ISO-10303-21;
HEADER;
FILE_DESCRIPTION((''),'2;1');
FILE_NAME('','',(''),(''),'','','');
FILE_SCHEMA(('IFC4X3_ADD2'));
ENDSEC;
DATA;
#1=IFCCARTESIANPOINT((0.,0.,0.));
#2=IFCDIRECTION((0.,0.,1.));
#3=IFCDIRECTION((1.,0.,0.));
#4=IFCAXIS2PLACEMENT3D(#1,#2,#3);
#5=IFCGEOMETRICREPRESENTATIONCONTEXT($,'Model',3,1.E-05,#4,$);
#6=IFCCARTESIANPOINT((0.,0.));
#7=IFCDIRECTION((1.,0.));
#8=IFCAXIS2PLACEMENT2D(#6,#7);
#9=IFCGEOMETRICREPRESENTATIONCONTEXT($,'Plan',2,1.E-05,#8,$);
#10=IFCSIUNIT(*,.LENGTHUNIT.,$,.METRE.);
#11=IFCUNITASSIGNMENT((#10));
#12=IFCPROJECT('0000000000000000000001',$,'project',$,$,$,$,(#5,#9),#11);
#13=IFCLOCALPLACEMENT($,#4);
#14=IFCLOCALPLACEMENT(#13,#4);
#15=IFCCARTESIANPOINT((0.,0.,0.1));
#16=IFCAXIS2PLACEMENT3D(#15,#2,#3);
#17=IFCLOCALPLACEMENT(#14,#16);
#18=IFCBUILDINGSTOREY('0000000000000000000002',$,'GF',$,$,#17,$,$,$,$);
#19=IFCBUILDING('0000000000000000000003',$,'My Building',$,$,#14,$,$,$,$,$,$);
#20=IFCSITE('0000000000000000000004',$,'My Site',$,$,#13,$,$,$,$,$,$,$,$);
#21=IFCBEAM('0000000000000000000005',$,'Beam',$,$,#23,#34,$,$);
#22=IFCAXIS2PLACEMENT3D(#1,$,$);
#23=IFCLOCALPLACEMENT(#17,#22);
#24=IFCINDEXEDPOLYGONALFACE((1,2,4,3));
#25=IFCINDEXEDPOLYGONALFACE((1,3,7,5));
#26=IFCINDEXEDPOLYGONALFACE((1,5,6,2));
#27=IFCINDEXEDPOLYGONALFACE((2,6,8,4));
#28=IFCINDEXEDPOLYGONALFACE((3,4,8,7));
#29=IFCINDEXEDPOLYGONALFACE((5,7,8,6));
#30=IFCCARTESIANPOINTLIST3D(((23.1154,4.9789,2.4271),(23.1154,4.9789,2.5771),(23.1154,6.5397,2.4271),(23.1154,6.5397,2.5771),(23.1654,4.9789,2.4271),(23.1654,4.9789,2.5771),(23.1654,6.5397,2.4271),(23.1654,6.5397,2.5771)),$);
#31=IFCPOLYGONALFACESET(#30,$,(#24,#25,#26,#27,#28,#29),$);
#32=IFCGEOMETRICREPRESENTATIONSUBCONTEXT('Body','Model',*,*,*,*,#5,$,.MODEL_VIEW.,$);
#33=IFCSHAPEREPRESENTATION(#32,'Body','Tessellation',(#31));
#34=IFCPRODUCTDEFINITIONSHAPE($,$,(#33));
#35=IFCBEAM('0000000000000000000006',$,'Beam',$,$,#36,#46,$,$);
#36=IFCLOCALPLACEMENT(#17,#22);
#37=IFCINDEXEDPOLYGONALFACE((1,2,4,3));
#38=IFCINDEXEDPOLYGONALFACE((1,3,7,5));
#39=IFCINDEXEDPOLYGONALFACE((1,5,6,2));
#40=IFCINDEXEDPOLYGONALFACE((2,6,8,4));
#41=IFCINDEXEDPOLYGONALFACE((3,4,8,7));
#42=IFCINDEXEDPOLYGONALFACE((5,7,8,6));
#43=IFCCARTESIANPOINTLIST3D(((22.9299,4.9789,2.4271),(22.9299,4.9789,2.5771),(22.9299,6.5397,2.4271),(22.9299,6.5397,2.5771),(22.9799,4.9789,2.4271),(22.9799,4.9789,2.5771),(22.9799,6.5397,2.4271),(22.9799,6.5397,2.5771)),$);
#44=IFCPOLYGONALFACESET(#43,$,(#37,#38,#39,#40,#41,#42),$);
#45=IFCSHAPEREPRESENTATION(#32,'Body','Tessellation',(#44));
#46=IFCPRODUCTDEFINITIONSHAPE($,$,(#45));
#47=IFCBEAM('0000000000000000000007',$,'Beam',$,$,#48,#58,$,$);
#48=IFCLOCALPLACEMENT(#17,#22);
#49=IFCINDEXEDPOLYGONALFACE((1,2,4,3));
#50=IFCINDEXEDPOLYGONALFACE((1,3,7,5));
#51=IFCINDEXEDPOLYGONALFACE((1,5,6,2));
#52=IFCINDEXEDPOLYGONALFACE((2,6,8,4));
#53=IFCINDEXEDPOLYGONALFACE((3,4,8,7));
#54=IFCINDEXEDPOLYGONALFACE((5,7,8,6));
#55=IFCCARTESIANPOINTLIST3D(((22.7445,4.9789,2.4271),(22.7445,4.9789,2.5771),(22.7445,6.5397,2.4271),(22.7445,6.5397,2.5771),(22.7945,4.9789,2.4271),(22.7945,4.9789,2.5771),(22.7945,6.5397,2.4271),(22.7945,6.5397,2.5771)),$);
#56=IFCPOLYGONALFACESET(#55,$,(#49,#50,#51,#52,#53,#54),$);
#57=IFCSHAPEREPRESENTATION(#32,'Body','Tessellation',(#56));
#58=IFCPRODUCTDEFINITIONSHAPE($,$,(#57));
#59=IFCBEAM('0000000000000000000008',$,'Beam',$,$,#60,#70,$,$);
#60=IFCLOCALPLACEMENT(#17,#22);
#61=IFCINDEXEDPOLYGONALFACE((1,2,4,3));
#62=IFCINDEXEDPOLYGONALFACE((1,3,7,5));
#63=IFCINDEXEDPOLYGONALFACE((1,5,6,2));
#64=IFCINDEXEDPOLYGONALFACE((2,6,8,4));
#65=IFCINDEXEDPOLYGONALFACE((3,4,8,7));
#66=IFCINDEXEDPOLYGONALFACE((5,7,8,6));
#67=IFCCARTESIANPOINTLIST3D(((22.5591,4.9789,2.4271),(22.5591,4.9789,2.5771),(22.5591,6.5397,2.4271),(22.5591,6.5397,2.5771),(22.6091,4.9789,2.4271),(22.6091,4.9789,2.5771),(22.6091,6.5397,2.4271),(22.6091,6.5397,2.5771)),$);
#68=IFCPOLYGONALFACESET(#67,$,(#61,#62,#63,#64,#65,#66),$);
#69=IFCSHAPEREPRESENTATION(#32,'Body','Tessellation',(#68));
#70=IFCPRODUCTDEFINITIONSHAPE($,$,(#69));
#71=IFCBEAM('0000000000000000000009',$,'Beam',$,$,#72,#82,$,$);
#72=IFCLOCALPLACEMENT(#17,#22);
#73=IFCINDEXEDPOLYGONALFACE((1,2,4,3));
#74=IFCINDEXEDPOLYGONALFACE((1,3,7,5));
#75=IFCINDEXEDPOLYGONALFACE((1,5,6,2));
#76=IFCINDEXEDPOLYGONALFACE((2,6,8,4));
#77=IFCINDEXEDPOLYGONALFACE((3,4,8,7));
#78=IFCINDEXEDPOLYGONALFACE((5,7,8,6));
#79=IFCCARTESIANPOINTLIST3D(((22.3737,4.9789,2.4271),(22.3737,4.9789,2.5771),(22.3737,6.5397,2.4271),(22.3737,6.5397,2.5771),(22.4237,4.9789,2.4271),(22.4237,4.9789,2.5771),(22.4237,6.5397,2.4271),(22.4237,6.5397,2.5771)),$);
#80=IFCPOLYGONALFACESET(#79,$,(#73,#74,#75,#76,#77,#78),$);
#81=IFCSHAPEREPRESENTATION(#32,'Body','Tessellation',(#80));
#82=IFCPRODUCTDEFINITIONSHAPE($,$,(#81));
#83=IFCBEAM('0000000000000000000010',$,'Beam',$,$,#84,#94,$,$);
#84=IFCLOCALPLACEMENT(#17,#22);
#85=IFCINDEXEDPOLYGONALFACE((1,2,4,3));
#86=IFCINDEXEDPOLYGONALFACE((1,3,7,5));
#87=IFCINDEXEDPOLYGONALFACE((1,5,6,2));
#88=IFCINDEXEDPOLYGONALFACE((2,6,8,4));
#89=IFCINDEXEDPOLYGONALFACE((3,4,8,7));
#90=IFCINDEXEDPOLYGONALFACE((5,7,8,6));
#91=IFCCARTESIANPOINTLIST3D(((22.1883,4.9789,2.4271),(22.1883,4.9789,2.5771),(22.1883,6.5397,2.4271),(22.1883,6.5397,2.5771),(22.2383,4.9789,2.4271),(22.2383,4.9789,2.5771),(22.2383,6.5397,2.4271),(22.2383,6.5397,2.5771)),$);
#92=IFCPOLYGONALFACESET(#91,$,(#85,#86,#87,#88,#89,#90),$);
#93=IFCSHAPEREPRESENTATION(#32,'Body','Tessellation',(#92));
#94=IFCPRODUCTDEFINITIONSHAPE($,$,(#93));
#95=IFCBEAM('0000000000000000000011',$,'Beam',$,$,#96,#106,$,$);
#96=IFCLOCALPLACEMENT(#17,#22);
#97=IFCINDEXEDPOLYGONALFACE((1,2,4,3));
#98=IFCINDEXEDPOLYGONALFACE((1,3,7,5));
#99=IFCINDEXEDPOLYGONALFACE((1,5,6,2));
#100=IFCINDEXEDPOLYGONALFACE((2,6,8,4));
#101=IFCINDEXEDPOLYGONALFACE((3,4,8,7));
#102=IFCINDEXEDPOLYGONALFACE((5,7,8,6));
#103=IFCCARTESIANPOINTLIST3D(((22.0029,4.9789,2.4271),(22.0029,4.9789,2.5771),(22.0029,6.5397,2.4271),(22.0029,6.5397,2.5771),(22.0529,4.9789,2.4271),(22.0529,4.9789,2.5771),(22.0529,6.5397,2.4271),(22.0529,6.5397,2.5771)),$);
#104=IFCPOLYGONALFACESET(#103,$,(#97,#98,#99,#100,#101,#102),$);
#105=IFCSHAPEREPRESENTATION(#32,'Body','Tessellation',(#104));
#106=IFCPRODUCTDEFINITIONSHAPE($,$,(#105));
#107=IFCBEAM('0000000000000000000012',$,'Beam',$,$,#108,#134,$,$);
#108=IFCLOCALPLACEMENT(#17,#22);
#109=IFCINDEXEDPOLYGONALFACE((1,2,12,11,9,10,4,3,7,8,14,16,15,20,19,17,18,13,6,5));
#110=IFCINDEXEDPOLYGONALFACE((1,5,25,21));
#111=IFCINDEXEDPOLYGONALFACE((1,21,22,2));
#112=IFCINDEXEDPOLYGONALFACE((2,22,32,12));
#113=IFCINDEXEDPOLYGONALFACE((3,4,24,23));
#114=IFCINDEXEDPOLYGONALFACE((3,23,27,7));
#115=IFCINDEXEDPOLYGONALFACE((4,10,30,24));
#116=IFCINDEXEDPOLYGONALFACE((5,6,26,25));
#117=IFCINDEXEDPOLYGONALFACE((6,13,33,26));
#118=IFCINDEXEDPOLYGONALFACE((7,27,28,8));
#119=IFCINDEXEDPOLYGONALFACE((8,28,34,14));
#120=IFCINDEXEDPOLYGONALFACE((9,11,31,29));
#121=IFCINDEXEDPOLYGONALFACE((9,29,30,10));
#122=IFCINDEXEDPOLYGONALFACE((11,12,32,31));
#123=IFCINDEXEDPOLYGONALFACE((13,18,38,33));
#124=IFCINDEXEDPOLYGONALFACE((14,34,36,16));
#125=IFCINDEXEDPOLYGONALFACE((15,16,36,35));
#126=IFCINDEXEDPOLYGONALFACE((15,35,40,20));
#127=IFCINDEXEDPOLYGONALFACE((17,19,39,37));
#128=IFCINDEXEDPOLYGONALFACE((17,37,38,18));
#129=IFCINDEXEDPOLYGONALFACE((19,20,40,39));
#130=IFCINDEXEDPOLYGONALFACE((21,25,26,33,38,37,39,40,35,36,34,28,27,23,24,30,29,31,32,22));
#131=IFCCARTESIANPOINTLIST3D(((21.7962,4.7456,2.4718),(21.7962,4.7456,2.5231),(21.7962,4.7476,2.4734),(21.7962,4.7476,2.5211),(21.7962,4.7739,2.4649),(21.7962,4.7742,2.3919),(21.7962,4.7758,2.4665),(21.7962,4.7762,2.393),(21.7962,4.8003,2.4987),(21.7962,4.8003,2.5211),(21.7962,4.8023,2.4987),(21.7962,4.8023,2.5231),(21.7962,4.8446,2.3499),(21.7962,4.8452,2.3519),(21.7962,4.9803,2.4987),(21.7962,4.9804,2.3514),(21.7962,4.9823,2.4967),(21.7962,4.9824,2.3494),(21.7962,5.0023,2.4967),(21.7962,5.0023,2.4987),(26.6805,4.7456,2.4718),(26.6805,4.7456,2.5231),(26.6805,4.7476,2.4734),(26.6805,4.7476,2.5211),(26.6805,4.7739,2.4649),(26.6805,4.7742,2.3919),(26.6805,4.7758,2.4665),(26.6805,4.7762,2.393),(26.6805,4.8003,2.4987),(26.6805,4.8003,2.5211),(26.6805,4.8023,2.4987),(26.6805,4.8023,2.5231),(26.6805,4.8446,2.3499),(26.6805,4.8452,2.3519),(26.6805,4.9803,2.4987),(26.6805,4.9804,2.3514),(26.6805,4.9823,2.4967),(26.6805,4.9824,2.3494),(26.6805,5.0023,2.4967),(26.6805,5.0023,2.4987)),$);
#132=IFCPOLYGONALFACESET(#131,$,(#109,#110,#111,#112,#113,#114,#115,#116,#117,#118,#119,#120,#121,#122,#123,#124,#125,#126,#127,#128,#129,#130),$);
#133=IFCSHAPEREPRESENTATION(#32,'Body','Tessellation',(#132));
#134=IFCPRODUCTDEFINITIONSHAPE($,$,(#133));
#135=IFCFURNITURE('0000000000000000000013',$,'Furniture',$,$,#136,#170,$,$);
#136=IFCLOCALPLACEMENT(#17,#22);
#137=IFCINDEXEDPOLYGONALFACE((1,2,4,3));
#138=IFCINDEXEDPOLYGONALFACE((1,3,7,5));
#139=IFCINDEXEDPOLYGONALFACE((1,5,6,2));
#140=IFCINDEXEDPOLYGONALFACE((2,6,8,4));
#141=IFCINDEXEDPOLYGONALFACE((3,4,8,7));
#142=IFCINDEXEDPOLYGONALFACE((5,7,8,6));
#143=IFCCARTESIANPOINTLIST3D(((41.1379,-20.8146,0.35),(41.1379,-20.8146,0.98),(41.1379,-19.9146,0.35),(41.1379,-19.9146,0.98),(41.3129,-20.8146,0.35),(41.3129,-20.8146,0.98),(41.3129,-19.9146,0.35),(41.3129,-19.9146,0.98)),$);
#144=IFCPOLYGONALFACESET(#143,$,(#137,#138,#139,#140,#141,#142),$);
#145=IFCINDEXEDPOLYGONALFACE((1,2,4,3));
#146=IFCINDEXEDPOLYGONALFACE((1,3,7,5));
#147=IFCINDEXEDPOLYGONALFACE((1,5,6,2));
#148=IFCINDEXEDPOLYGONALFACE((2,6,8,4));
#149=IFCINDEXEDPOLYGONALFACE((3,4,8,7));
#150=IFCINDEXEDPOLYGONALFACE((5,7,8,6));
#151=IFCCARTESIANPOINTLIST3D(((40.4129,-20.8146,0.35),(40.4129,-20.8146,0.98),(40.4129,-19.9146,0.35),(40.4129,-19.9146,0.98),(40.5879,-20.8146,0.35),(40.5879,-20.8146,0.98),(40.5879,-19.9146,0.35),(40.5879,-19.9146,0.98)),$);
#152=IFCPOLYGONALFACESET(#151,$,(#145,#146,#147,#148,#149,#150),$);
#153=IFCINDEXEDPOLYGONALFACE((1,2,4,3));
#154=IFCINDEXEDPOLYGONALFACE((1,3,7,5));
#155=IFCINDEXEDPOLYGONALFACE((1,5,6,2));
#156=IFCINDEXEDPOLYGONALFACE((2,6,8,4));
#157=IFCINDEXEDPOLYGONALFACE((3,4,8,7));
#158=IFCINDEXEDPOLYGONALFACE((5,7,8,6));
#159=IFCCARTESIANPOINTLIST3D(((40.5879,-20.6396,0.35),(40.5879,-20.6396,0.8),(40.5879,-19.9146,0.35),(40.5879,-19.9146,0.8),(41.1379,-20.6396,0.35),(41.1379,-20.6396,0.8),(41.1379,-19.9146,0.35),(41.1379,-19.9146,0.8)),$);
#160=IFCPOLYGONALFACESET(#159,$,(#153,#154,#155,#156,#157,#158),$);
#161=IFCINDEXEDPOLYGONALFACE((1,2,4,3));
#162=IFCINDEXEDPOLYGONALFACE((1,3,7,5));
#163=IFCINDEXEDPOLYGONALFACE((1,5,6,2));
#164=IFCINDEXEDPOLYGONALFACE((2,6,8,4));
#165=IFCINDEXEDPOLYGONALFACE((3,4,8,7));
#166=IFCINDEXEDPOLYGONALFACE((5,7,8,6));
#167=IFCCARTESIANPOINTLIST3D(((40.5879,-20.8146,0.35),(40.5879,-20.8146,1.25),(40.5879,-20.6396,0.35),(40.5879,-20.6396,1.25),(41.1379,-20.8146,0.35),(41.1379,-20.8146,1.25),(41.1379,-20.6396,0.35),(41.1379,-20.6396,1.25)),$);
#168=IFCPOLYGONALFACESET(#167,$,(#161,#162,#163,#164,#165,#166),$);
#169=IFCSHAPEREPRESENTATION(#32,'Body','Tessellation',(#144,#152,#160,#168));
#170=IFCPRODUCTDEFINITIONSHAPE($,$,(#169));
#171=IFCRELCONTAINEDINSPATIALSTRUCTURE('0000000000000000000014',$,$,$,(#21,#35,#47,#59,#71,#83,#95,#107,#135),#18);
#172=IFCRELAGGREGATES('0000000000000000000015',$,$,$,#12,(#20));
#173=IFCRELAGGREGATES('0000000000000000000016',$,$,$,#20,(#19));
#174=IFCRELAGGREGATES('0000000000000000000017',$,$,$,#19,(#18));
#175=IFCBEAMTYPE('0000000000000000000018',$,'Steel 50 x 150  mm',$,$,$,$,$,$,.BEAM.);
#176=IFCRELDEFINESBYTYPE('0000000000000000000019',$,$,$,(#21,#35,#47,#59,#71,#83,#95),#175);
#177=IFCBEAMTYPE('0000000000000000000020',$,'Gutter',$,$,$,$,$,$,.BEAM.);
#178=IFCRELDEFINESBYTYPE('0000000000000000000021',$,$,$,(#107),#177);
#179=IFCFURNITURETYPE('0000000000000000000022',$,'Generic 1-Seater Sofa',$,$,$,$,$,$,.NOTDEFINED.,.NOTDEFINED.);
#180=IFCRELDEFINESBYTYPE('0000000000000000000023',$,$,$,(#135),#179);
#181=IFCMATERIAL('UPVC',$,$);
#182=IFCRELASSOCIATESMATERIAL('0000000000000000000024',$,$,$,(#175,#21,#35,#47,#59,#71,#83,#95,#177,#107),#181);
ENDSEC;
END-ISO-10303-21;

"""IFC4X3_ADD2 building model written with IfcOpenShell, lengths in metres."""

from ifc_helpers import new_model, entity, si_unit, frame, origin_with_axes, origin_2d_with_axis, place, context, subcontext, project, spatial, line, indexed_curve, rectangle, outline, extrude, shape, source, transform, mapped, material, material_profile, profile_set, profile_usage, type_object, type_shapes, element, save


model = new_model("IFC4X3_ADD2")

# Units and contexts
model_context = context("Model", 3, precision=1e-05, world=origin_with_axes())
plan_context = context("Plan", 2, precision=1e-05, world=origin_2d_with_axis())
body_context_1 = subcontext(model_context, "Body", "Model", "MODEL_VIEW")
body_context_2 = subcontext(plan_context, "Body", "Plan", "PLAN_VIEW")
ifc_project = project(units=[si_unit("LENGTHUNIT", "METRE")], contexts=[model_context, plan_context])

# Site, building, storey
site_placement = place(None, origin_with_axes())
site = spatial("IfcSite", under=ifc_project, at=site_placement, Name="My Site")
building_placement = place(site_placement, origin_with_axes())
building = spatial("IfcBuilding", under=site, at=building_placement, Name="My Building")
storey_placement = place(building_placement, frame((0.0, 0.0, 0.1), z_axis=(0.0, 0.0, 1.0), x_axis=(1.0, 0.0, 0.0)))
storey = spatial("IfcBuildingStorey", under=building, at=storey_placement, Name="GF")

# Beams
ifc_material_1 = material(Name="UPVC")
ifc_material_profile_1 = material_profile(ifc_material_1, rectangle(XDim=0.05, YDim=0.15))
ifc_profile_set_1 = profile_set([ifc_material_profile_1])
beam_type_1 = type_object("IfcBeamType", Name="Steel 50 x 150  mm", PredefinedType="BEAM", material=ifc_profile_set_1)
ifc_profile_usage_1 = profile_usage(ifc_profile_set_1)
beam_1_placement = place(storey_placement, frame((23.1404, 6.5397, 2.5021), z_axis=(0.0, -1.0, 0.0), x_axis=(1.0, 0.0, 0.0)))
element("IfcBeam", 1, at=beam_1_placement, inside=storey, type_object=beam_type_1, material=ifc_profile_usage_1, Name="Beam", context=body_context_1, shape_type="SweptSolid", body=[
    extrude(rectangle(XDim=0.05, YDim=0.15), origin_with_axes(), (0.0, 0.0, 1.0), 1.5608),
])
ifc_profile_usage_2 = profile_usage(ifc_profile_set_1)
beam_2_placement = place(storey_placement, frame((22.9549, 6.5397, 2.5021), z_axis=(0.0, -1.0, 0.0), x_axis=(1.0, 0.0, 0.0)))
element("IfcBeam", 2, at=beam_2_placement, inside=storey, type_object=beam_type_1, material=ifc_profile_usage_2, Name="Beam", context=body_context_1, shape_type="SweptSolid", body=[
    extrude(rectangle(XDim=0.05, YDim=0.15), origin_with_axes(), (0.0, 0.0, 1.0), 1.5608),
])
ifc_profile_usage_3 = profile_usage(ifc_profile_set_1)
beam_3_placement = place(storey_placement, frame((22.7695, 6.5397, 2.5021), z_axis=(0.0, -1.0, 0.0), x_axis=(1.0, 0.0, 0.0)))
element("IfcBeam", 3, at=beam_3_placement, inside=storey, type_object=beam_type_1, material=ifc_profile_usage_3, Name="Beam", context=body_context_1, shape_type="SweptSolid", body=[
    extrude(rectangle(XDim=0.05, YDim=0.15), origin_with_axes(), (0.0, 0.0, 1.0), 1.5608),
])
ifc_profile_usage_4 = profile_usage(ifc_profile_set_1)
beam_4_placement = place(storey_placement, frame((22.5841, 6.5397, 2.5021), z_axis=(0.0, -1.0, 0.0), x_axis=(1.0, 0.0, 0.0)))
element("IfcBeam", 4, at=beam_4_placement, inside=storey, type_object=beam_type_1, material=ifc_profile_usage_4, Name="Beam", context=body_context_1, shape_type="SweptSolid", body=[
    extrude(rectangle(XDim=0.05, YDim=0.15), origin_with_axes(), (0.0, 0.0, 1.0), 1.5608),
])
ifc_profile_usage_5 = profile_usage(ifc_profile_set_1)
beam_5_placement = place(storey_placement, frame((22.3987, 6.5397, 2.5021), z_axis=(0.0, -1.0, 0.0), x_axis=(1.0, 0.0, 0.0)))
element("IfcBeam", 5, at=beam_5_placement, inside=storey, type_object=beam_type_1, material=ifc_profile_usage_5, Name="Beam", context=body_context_1, shape_type="SweptSolid", body=[
    extrude(rectangle(XDim=0.05, YDim=0.15), origin_with_axes(), (0.0, 0.0, 1.0), 1.5608),
])
ifc_profile_usage_6 = profile_usage(ifc_profile_set_1)
beam_6_placement = place(storey_placement, frame((22.2133, 6.5397, 2.5021), z_axis=(0.0, -1.0, 0.0), x_axis=(1.0, 0.0, 0.0)))
element("IfcBeam", 6, at=beam_6_placement, inside=storey, type_object=beam_type_1, material=ifc_profile_usage_6, Name="Beam", context=body_context_1, shape_type="SweptSolid", body=[
    extrude(rectangle(XDim=0.05, YDim=0.15), origin_with_axes(), (0.0, 0.0, 1.0), 1.5608),
])
ifc_profile_usage_7 = profile_usage(ifc_profile_set_1)
beam_7_placement = place(storey_placement, frame((22.0279, 6.5397, 2.5021), z_axis=(0.0, -1.0, 0.0), x_axis=(1.0, 0.0, 0.0)))
element("IfcBeam", 7, at=beam_7_placement, inside=storey, type_object=beam_type_1, material=ifc_profile_usage_7, Name="Beam", context=body_context_1, shape_type="SweptSolid", body=[
    extrude(rectangle(XDim=0.05, YDim=0.15), origin_with_axes(), (0.0, 0.0, 1.0), 1.5608),
])
ifc_material_profile_2 = material_profile(ifc_material_1, outline(indexed_curve([(0.0548, 0.1717), (0.002, 0.1717), (0.002, 0.124), (0.0303, 0.1171), (0.0307, 0.0436), (0.0996, 0.0025), (0.2349, 0.002), (0.2347, 0.1494), (0.2567, 0.1494), (0.2567, 0.1474), (0.2367, 0.1474), (0.2369, 0.0), (0.0991, 0.0005), (0.0287, 0.0425), (0.0283, 0.1155), (0.0, 0.1224), (0.0, 0.1737), (0.0568, 0.1737), (0.0568, 0.1494), (0.0548, 0.1494), (0.0548, 0.1717)])))
ifc_profile_set_2 = profile_set([ifc_material_profile_2])
ifc_profile_usage_8 = profile_usage(ifc_profile_set_2)
beam_type_2 = type_object("IfcBeamType", Name="Gutter", PredefinedType="BEAM", material=ifc_profile_set_2)
beam_8_placement = place(storey_placement, frame((21.7962, 4.7456, 2.3494), z_axis=(1.0, 0.0, 0.0), x_axis=(0.0, 1.0, 0.0)))
element("IfcBeam", 8, at=beam_8_placement, inside=storey, type_object=beam_type_2, material=ifc_profile_usage_8, Name="Beam", context=body_context_1, shape_type="SweptSolid", body=[
    extrude(outline(indexed_curve([(0.0548, 0.1717), (0.002, 0.1717), (0.002, 0.124), (0.0303, 0.1171), (0.0307, 0.0436), (0.0996, 0.0025), (0.2349, 0.002), (0.2347, 0.1494), (0.2567, 0.1494), (0.2567, 0.1474), (0.2367, 0.1474), (0.2369, 0.0), (0.0991, 0.0005), (0.0287, 0.0425), (0.0283, 0.1155), (0.0, 0.1224), (0.0, 0.1737), (0.0568, 0.1737), (0.0568, 0.1494), (0.0548, 0.1494), (0.0548, 0.1717)])), origin_with_axes(), (0.0, 0.0, 1.0), 4.8842),
])

# Furniture
furniture_type_1 = type_object("IfcFurnitureType", Name="Generic 1-Seater Sofa", AssemblyPlace="NOTDEFINED", PredefinedType="NOTDEFINED")
shared_shape_1 = source(origin_with_axes(), body_context_1, "Body", "SweptSolid", [
    extrude(outline(indexed_curve([(0.0, 0.0), (0.175, 0.0), (0.175, 0.9), (0.0, 0.9)], segments=[line(4, 1), line(1, 2), line(2, 3), line(3, 4)], self_intersect=False)), frame((-0.45, -0.9, 0.0), z_axis=(0.0, 0.0, 1.0), x_axis=(1.0, 0.0, 0.0)), (0.0, 0.0, 1.0), 0.63),
    extrude(outline(indexed_curve([(0.0, 0.0), (0.175, 0.0), (0.175, 0.9), (0.0, 0.9)], segments=[line(1, 2, 3, 4, 1)])), frame((0.275, -0.9, 0.0), z_axis=(0.0, 0.0, 1.0), x_axis=(1.0, 0.0, 0.0)), (0.0, 0.0, 1.0), 0.63),
    extrude(outline(indexed_curve([(0.175, 0.0), (0.725, 0.0), (0.725, 0.725), (0.175, 0.725)], segments=[line(1, 2, 3, 4, 1)])), frame((-0.45, -0.9, 0.0), z_axis=(0.0, 0.0, 1.0), x_axis=(1.0, 0.0, 0.0)), (0.0, 0.0, 1.0), 0.45),
    extrude(outline(indexed_curve([(0.175, 0.725), (0.725, 0.725), (0.725, 0.9), (0.175, 0.9)], segments=[line(1, 2, 3, 4, 1)])), frame((-0.45, -0.9, 0.0), z_axis=(0.0, 0.0, 1.0), x_axis=(1.0, 0.0, 0.0)), (0.0, 0.0, 1.0), 0.9),
])
shared_shape_2 = source(origin_with_axes(), body_context_2, "Body", "Annotation2D", [
    entity("IfcGeometricCurveSet", [entity("IfcIndexedPolyCurve", entity("IfcCartesianPointList2D", [[0.275, -0.175], [0.275, -0.9], [0.45, -0.9], [0.45, 0.0], [0.275, 0.0], [0.275, -0.9], [-0.275, -0.9], [-0.275, 0.0], [-0.275, -0.175], [0.275, -0.175], [0.275, 0.0], [-0.275, 0.0], [-0.45, 0.0], [-0.45, -0.9], [-0.275, -0.9], [-0.275, -0.175]]))]),
])
type_shapes(furniture_type_1, [shared_shape_1, shared_shape_2])
for number, where, z_axis, x_axis, name in (
    (9, (40.8629, -20.8146, 0.35), (0.0, 0.0, 1.0), (-1.0, 0.0, 0.0), "Furniture"),
):
    element("IfcFurniture", number, at=place(storey_placement, frame(where, z_axis=z_axis, x_axis=x_axis)), inside=storey, type_object=furniture_type_1, Name=name, shapes=[
        shape(body_context_1, "Body", "MappedRepresentation", [mapped(shared_shape_1, transform((0.0, 0.0, 0.0), x_axis=(1.0, 0.0, 0.0), y_axis=(0.0, 1.0, 0.0), z_axis=(0.0, 0.0, 1.0), scale=1.0))]),
        shape(body_context_2, "Body", "MappedRepresentation", [mapped(shared_shape_2, transform((0.0, 0.0, 0.0), x_axis=(1.0, 0.0, 0.0), y_axis=(0.0, 1.0, 0.0), z_axis=(0.0, 0.0, 1.0), scale=1.0))]),
    ])

save(model, "model.ifc")
